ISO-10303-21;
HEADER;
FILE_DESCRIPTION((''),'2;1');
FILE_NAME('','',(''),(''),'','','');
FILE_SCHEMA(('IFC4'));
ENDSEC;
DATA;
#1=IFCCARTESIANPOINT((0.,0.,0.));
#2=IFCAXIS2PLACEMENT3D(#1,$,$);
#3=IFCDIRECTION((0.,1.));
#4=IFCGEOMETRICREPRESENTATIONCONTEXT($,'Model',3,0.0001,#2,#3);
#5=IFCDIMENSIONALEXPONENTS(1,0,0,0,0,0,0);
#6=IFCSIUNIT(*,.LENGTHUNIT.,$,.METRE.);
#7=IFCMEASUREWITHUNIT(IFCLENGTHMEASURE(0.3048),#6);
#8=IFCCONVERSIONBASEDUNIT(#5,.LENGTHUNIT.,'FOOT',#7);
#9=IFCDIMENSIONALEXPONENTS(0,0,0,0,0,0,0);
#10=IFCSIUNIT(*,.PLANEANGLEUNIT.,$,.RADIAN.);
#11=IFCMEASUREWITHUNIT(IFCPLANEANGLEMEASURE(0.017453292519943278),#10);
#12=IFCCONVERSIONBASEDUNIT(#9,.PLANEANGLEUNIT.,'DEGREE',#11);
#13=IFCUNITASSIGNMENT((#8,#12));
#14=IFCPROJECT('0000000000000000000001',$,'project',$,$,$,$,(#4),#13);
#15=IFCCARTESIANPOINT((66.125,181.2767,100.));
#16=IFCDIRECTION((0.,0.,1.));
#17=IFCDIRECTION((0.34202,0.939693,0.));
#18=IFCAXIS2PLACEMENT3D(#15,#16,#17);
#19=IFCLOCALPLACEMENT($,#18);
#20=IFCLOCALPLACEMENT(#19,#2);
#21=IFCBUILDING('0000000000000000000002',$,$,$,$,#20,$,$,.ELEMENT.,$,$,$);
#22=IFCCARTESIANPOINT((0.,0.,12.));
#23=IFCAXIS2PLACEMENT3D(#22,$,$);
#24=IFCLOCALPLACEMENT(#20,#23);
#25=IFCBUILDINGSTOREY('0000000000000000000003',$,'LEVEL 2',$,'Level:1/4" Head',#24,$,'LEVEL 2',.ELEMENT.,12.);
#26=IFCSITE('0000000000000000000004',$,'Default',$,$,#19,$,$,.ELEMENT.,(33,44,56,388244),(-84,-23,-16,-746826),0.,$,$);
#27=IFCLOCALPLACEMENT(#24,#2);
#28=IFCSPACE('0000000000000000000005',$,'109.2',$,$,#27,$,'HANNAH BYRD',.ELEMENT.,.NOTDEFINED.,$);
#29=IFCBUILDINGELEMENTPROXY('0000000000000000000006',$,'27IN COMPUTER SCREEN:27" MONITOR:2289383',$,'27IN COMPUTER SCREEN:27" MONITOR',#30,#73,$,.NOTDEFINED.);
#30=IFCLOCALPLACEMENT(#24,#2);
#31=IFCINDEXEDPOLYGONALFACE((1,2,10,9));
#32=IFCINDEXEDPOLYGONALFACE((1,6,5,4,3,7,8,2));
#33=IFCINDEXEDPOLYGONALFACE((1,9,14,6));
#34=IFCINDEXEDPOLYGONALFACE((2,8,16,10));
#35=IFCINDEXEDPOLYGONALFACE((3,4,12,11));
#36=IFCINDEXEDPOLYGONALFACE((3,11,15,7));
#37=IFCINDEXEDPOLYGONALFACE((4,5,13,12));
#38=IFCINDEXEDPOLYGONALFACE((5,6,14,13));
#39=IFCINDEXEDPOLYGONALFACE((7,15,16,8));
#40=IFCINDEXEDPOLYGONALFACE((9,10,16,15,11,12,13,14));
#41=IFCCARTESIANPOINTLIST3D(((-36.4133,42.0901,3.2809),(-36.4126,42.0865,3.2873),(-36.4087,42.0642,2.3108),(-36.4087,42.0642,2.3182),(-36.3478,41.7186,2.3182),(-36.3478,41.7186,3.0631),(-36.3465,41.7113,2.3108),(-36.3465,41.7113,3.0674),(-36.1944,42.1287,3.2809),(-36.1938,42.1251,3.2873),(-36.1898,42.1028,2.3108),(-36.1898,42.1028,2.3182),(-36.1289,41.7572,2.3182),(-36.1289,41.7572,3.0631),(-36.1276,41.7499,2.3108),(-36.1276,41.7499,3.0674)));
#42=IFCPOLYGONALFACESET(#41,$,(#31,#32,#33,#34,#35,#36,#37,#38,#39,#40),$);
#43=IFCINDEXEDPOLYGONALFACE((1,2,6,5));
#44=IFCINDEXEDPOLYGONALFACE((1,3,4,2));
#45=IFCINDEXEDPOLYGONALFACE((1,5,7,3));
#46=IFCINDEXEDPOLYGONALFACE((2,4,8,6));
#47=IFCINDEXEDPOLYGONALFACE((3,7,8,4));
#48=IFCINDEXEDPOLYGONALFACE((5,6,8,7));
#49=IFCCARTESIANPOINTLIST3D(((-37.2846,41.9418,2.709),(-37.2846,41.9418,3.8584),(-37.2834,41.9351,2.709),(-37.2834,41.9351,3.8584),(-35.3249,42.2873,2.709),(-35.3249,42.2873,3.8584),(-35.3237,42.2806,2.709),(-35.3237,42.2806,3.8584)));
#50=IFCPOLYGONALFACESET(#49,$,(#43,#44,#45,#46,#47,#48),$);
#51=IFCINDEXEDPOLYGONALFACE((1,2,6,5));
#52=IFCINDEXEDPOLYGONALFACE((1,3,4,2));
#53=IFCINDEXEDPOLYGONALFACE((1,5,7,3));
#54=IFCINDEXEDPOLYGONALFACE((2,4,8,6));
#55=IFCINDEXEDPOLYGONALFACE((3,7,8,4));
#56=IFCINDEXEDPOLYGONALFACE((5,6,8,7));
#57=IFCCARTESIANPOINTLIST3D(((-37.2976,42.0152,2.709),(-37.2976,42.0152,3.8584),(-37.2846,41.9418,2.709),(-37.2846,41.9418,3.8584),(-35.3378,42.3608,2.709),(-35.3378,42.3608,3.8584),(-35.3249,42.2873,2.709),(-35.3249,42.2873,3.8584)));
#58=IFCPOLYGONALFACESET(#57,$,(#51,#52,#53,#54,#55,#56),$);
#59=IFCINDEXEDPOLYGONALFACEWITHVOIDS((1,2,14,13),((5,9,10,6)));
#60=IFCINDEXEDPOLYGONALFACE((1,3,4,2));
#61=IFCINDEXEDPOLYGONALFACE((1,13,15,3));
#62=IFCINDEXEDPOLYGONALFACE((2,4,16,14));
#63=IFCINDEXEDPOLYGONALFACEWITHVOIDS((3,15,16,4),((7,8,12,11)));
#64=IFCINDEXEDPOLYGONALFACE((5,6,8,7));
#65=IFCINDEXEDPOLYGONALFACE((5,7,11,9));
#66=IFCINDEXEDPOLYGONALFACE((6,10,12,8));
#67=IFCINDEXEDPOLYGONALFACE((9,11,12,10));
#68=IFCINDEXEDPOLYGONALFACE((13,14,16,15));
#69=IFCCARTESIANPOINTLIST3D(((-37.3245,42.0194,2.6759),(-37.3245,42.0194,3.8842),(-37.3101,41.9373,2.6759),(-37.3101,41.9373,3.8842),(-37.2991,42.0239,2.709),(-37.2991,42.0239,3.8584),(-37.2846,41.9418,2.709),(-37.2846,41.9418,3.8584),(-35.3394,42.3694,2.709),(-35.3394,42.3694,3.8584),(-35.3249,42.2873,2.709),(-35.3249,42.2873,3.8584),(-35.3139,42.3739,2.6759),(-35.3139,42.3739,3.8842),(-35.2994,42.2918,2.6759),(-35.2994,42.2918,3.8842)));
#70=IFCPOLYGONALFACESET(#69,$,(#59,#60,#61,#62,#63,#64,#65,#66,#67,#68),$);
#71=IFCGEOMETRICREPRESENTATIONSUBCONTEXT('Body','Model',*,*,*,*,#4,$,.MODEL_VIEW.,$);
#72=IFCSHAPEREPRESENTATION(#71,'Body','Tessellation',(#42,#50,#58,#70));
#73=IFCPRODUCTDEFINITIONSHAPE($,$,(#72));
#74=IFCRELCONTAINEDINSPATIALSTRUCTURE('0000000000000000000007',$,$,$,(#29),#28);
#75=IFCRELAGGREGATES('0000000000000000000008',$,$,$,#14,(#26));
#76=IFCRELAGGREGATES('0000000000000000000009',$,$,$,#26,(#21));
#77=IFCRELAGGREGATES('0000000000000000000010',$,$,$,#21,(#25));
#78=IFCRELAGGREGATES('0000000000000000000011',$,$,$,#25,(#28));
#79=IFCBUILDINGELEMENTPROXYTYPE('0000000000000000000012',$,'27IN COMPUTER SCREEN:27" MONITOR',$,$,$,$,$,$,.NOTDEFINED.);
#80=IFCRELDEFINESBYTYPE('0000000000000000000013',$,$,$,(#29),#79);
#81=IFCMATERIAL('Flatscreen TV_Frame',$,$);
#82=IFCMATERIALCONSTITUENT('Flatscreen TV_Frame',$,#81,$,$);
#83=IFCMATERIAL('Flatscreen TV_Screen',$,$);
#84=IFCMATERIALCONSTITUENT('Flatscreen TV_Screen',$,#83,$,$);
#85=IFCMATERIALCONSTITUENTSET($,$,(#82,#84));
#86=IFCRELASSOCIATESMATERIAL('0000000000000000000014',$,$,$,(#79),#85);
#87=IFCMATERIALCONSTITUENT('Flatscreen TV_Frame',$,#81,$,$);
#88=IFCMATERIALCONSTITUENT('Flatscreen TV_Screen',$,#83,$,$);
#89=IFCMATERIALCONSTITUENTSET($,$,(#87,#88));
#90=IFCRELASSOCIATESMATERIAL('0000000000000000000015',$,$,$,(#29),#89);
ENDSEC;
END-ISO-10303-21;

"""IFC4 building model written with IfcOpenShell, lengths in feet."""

from ifc_helpers import new_model, entity, si_unit, converted_unit, direction, frame, frame_2d, origin, origin_2d_with_axis, place, context, subcontext, project, spatial, polyline, rectangle, outline, extrude, source, transform, mapped, material, constituent, constituent_set, type_object, type_shapes, element, save


model = new_model("IFC4")

# Units and contexts
model_context = context("Model", 3, precision=0.0001, world=origin(), true_north=direction((0.0, 1.0)))
body_context = subcontext(model_context, "Body", "Model", "MODEL_VIEW")
ifc_project = project(units=[converted_unit("LENGTHUNIT", "FOOT", entity("IfcLengthMeasure", 0.3048), si_unit("LENGTHUNIT", "METRE"), dimensions=[1, 0, 0, 0, 0, 0, 0]), converted_unit("PLANEANGLEUNIT", "DEGREE", entity("IfcPlaneAngleMeasure", 0.017453292519943278), si_unit("PLANEANGLEUNIT", "RADIAN"), dimensions=[0, 0, 0, 0, 0, 0, 0])], contexts=[model_context])

# Site, building, storey
site_placement = place(None, frame((66.125, 181.2767, 100.0), z_axis=(0.0, 0.0, 1.0), x_axis=(0.34202, 0.939693, 0.0)))
site = spatial("IfcSite", under=ifc_project, at=site_placement, Name="Default", CompositionType="ELEMENT", RefLatitude=(33, 44, 56, 388244), RefLongitude=(-84, -23, -16, -746826), RefElevation=0.0)
building_placement = place(site_placement, origin())
building = spatial("IfcBuilding", under=site, at=building_placement, CompositionType="ELEMENT")
storey_placement = place(building_placement, frame((0.0, 0.0, 12.0)))
storey = spatial("IfcBuildingStorey", under=building, at=storey_placement, Name="LEVEL 2", ObjectType="Level:1/4\" Head", LongName="LEVEL 2", CompositionType="ELEMENT", Elevation=12.0)

# Shared definitions
space_1_placement = place(storey_placement, origin())
space_1 = spatial("IfcSpace", under=storey, at=space_1_placement, Name="109.2", LongName="HANNAH BYRD", CompositionType="ELEMENT", PredefinedType="NOTDEFINED")

# Building element proxy
ifc_material_1 = material(Name="Flatscreen TV_Frame")
ifc_material_2 = material(Name="Flatscreen TV_Screen")
ifc_constituent_1 = constituent(ifc_material_1, Name="Flatscreen TV_Frame")
ifc_constituent_2 = constituent(ifc_material_2, Name="Flatscreen TV_Screen")
ifc_constituent_set_1 = constituent_set(constituents=[ifc_constituent_1, ifc_constituent_2])
building_element_proxy_type_1 = type_object("IfcBuildingElementProxyType", Name="27IN COMPUTER SCREEN:27\" MONITOR", PredefinedType="NOTDEFINED", material=ifc_constituent_set_1)
shared_shape_1 = source(origin(), body_context, "Body", "SweptSolid", [
    extrude(outline(polyline([(0.3657, -0.4392), (0.3731, -0.4392), (0.3731, 0.0007), (-0.2821, 0.379), (-0.4613, 0.0686), (-0.4548, 0.0649), (-0.2794, 0.3688), (0.3657, -0.0036), (0.3657, -0.4392)])), frame((-0.1111, 0.0264, 0.0687), z_axis=(1.0, 0.0, 0.0), x_axis=(0.0, -0.5, 0.866025)), (0.0, 0.0, 1.0), 0.2222),
    extrude(rectangle(XDim=1.9899, YDim=0.0068, at=origin_2d_with_axis()), frame((0.0, 0.2257, 0.0331), z_axis=(0.0, 0.0, 1.0), x_axis=(-1.0, 0.0, 0.0)), (0.0, 0.0, 1.0), 1.1493),
    extrude(rectangle(XDim=1.9899, YDim=0.0746, at=frame_2d((0.0, 0.0), x_axis=(1.0, 0.0))), frame((0.0, 0.2664, 0.0331), z_axis=(0.0, 0.0, 1.0), x_axis=(-1.0, 0.0, 0.0)), (0.0, 0.0, 1.0), 1.1493),
    extrude(outline(polyline([(-0.6042, -1.0208), (0.6042, -1.0208), (0.6042, 1.0208), (-0.6042, 1.0208), (-0.6042, -1.0208)]), holes=[polyline([(-0.5783, -0.995), (-0.5783, 0.995), (0.571, 0.995), (0.571, -0.995), (-0.5783, -0.995)])]), frame((0.0, 0.2292, 0.6042), z_axis=(0.0, 1.0, 0.0), x_axis=(0.0, 0.0, -1.0)), (0.0, 0.0, 1.0), 0.0833),
])
type_shapes(building_element_proxy_type_1, [shared_shape_1])
ifc_constituent_3 = constituent(ifc_material_1, Name="Flatscreen TV_Frame")
ifc_constituent_4 = constituent(ifc_material_2, Name="Flatscreen TV_Screen")
ifc_constituent_set_2 = constituent_set(constituents=[ifc_constituent_3, ifc_constituent_4])
proxy_1_placement = place(space_1_placement, frame((-36.265, 41.8889, 2.6759), z_axis=(0.0, 0.0, 1.0), x_axis=(0.984808, 0.173648, 0.0)))
element("IfcBuildingElementProxy", 1, at=proxy_1_placement, inside=space_1, type_object=building_element_proxy_type_1, material=ifc_constituent_set_2, Name="27IN COMPUTER SCREEN:27\" MONITOR:2289383", ObjectType="27IN COMPUTER SCREEN:27\" MONITOR", PredefinedType="NOTDEFINED", context=body_context, shape_type="MappedRepresentation", body=[
    mapped(shared_shape_1, transform((0.0, 0.0, 0.0), scale=1.0)),
])

save(model, "model.ifc")
